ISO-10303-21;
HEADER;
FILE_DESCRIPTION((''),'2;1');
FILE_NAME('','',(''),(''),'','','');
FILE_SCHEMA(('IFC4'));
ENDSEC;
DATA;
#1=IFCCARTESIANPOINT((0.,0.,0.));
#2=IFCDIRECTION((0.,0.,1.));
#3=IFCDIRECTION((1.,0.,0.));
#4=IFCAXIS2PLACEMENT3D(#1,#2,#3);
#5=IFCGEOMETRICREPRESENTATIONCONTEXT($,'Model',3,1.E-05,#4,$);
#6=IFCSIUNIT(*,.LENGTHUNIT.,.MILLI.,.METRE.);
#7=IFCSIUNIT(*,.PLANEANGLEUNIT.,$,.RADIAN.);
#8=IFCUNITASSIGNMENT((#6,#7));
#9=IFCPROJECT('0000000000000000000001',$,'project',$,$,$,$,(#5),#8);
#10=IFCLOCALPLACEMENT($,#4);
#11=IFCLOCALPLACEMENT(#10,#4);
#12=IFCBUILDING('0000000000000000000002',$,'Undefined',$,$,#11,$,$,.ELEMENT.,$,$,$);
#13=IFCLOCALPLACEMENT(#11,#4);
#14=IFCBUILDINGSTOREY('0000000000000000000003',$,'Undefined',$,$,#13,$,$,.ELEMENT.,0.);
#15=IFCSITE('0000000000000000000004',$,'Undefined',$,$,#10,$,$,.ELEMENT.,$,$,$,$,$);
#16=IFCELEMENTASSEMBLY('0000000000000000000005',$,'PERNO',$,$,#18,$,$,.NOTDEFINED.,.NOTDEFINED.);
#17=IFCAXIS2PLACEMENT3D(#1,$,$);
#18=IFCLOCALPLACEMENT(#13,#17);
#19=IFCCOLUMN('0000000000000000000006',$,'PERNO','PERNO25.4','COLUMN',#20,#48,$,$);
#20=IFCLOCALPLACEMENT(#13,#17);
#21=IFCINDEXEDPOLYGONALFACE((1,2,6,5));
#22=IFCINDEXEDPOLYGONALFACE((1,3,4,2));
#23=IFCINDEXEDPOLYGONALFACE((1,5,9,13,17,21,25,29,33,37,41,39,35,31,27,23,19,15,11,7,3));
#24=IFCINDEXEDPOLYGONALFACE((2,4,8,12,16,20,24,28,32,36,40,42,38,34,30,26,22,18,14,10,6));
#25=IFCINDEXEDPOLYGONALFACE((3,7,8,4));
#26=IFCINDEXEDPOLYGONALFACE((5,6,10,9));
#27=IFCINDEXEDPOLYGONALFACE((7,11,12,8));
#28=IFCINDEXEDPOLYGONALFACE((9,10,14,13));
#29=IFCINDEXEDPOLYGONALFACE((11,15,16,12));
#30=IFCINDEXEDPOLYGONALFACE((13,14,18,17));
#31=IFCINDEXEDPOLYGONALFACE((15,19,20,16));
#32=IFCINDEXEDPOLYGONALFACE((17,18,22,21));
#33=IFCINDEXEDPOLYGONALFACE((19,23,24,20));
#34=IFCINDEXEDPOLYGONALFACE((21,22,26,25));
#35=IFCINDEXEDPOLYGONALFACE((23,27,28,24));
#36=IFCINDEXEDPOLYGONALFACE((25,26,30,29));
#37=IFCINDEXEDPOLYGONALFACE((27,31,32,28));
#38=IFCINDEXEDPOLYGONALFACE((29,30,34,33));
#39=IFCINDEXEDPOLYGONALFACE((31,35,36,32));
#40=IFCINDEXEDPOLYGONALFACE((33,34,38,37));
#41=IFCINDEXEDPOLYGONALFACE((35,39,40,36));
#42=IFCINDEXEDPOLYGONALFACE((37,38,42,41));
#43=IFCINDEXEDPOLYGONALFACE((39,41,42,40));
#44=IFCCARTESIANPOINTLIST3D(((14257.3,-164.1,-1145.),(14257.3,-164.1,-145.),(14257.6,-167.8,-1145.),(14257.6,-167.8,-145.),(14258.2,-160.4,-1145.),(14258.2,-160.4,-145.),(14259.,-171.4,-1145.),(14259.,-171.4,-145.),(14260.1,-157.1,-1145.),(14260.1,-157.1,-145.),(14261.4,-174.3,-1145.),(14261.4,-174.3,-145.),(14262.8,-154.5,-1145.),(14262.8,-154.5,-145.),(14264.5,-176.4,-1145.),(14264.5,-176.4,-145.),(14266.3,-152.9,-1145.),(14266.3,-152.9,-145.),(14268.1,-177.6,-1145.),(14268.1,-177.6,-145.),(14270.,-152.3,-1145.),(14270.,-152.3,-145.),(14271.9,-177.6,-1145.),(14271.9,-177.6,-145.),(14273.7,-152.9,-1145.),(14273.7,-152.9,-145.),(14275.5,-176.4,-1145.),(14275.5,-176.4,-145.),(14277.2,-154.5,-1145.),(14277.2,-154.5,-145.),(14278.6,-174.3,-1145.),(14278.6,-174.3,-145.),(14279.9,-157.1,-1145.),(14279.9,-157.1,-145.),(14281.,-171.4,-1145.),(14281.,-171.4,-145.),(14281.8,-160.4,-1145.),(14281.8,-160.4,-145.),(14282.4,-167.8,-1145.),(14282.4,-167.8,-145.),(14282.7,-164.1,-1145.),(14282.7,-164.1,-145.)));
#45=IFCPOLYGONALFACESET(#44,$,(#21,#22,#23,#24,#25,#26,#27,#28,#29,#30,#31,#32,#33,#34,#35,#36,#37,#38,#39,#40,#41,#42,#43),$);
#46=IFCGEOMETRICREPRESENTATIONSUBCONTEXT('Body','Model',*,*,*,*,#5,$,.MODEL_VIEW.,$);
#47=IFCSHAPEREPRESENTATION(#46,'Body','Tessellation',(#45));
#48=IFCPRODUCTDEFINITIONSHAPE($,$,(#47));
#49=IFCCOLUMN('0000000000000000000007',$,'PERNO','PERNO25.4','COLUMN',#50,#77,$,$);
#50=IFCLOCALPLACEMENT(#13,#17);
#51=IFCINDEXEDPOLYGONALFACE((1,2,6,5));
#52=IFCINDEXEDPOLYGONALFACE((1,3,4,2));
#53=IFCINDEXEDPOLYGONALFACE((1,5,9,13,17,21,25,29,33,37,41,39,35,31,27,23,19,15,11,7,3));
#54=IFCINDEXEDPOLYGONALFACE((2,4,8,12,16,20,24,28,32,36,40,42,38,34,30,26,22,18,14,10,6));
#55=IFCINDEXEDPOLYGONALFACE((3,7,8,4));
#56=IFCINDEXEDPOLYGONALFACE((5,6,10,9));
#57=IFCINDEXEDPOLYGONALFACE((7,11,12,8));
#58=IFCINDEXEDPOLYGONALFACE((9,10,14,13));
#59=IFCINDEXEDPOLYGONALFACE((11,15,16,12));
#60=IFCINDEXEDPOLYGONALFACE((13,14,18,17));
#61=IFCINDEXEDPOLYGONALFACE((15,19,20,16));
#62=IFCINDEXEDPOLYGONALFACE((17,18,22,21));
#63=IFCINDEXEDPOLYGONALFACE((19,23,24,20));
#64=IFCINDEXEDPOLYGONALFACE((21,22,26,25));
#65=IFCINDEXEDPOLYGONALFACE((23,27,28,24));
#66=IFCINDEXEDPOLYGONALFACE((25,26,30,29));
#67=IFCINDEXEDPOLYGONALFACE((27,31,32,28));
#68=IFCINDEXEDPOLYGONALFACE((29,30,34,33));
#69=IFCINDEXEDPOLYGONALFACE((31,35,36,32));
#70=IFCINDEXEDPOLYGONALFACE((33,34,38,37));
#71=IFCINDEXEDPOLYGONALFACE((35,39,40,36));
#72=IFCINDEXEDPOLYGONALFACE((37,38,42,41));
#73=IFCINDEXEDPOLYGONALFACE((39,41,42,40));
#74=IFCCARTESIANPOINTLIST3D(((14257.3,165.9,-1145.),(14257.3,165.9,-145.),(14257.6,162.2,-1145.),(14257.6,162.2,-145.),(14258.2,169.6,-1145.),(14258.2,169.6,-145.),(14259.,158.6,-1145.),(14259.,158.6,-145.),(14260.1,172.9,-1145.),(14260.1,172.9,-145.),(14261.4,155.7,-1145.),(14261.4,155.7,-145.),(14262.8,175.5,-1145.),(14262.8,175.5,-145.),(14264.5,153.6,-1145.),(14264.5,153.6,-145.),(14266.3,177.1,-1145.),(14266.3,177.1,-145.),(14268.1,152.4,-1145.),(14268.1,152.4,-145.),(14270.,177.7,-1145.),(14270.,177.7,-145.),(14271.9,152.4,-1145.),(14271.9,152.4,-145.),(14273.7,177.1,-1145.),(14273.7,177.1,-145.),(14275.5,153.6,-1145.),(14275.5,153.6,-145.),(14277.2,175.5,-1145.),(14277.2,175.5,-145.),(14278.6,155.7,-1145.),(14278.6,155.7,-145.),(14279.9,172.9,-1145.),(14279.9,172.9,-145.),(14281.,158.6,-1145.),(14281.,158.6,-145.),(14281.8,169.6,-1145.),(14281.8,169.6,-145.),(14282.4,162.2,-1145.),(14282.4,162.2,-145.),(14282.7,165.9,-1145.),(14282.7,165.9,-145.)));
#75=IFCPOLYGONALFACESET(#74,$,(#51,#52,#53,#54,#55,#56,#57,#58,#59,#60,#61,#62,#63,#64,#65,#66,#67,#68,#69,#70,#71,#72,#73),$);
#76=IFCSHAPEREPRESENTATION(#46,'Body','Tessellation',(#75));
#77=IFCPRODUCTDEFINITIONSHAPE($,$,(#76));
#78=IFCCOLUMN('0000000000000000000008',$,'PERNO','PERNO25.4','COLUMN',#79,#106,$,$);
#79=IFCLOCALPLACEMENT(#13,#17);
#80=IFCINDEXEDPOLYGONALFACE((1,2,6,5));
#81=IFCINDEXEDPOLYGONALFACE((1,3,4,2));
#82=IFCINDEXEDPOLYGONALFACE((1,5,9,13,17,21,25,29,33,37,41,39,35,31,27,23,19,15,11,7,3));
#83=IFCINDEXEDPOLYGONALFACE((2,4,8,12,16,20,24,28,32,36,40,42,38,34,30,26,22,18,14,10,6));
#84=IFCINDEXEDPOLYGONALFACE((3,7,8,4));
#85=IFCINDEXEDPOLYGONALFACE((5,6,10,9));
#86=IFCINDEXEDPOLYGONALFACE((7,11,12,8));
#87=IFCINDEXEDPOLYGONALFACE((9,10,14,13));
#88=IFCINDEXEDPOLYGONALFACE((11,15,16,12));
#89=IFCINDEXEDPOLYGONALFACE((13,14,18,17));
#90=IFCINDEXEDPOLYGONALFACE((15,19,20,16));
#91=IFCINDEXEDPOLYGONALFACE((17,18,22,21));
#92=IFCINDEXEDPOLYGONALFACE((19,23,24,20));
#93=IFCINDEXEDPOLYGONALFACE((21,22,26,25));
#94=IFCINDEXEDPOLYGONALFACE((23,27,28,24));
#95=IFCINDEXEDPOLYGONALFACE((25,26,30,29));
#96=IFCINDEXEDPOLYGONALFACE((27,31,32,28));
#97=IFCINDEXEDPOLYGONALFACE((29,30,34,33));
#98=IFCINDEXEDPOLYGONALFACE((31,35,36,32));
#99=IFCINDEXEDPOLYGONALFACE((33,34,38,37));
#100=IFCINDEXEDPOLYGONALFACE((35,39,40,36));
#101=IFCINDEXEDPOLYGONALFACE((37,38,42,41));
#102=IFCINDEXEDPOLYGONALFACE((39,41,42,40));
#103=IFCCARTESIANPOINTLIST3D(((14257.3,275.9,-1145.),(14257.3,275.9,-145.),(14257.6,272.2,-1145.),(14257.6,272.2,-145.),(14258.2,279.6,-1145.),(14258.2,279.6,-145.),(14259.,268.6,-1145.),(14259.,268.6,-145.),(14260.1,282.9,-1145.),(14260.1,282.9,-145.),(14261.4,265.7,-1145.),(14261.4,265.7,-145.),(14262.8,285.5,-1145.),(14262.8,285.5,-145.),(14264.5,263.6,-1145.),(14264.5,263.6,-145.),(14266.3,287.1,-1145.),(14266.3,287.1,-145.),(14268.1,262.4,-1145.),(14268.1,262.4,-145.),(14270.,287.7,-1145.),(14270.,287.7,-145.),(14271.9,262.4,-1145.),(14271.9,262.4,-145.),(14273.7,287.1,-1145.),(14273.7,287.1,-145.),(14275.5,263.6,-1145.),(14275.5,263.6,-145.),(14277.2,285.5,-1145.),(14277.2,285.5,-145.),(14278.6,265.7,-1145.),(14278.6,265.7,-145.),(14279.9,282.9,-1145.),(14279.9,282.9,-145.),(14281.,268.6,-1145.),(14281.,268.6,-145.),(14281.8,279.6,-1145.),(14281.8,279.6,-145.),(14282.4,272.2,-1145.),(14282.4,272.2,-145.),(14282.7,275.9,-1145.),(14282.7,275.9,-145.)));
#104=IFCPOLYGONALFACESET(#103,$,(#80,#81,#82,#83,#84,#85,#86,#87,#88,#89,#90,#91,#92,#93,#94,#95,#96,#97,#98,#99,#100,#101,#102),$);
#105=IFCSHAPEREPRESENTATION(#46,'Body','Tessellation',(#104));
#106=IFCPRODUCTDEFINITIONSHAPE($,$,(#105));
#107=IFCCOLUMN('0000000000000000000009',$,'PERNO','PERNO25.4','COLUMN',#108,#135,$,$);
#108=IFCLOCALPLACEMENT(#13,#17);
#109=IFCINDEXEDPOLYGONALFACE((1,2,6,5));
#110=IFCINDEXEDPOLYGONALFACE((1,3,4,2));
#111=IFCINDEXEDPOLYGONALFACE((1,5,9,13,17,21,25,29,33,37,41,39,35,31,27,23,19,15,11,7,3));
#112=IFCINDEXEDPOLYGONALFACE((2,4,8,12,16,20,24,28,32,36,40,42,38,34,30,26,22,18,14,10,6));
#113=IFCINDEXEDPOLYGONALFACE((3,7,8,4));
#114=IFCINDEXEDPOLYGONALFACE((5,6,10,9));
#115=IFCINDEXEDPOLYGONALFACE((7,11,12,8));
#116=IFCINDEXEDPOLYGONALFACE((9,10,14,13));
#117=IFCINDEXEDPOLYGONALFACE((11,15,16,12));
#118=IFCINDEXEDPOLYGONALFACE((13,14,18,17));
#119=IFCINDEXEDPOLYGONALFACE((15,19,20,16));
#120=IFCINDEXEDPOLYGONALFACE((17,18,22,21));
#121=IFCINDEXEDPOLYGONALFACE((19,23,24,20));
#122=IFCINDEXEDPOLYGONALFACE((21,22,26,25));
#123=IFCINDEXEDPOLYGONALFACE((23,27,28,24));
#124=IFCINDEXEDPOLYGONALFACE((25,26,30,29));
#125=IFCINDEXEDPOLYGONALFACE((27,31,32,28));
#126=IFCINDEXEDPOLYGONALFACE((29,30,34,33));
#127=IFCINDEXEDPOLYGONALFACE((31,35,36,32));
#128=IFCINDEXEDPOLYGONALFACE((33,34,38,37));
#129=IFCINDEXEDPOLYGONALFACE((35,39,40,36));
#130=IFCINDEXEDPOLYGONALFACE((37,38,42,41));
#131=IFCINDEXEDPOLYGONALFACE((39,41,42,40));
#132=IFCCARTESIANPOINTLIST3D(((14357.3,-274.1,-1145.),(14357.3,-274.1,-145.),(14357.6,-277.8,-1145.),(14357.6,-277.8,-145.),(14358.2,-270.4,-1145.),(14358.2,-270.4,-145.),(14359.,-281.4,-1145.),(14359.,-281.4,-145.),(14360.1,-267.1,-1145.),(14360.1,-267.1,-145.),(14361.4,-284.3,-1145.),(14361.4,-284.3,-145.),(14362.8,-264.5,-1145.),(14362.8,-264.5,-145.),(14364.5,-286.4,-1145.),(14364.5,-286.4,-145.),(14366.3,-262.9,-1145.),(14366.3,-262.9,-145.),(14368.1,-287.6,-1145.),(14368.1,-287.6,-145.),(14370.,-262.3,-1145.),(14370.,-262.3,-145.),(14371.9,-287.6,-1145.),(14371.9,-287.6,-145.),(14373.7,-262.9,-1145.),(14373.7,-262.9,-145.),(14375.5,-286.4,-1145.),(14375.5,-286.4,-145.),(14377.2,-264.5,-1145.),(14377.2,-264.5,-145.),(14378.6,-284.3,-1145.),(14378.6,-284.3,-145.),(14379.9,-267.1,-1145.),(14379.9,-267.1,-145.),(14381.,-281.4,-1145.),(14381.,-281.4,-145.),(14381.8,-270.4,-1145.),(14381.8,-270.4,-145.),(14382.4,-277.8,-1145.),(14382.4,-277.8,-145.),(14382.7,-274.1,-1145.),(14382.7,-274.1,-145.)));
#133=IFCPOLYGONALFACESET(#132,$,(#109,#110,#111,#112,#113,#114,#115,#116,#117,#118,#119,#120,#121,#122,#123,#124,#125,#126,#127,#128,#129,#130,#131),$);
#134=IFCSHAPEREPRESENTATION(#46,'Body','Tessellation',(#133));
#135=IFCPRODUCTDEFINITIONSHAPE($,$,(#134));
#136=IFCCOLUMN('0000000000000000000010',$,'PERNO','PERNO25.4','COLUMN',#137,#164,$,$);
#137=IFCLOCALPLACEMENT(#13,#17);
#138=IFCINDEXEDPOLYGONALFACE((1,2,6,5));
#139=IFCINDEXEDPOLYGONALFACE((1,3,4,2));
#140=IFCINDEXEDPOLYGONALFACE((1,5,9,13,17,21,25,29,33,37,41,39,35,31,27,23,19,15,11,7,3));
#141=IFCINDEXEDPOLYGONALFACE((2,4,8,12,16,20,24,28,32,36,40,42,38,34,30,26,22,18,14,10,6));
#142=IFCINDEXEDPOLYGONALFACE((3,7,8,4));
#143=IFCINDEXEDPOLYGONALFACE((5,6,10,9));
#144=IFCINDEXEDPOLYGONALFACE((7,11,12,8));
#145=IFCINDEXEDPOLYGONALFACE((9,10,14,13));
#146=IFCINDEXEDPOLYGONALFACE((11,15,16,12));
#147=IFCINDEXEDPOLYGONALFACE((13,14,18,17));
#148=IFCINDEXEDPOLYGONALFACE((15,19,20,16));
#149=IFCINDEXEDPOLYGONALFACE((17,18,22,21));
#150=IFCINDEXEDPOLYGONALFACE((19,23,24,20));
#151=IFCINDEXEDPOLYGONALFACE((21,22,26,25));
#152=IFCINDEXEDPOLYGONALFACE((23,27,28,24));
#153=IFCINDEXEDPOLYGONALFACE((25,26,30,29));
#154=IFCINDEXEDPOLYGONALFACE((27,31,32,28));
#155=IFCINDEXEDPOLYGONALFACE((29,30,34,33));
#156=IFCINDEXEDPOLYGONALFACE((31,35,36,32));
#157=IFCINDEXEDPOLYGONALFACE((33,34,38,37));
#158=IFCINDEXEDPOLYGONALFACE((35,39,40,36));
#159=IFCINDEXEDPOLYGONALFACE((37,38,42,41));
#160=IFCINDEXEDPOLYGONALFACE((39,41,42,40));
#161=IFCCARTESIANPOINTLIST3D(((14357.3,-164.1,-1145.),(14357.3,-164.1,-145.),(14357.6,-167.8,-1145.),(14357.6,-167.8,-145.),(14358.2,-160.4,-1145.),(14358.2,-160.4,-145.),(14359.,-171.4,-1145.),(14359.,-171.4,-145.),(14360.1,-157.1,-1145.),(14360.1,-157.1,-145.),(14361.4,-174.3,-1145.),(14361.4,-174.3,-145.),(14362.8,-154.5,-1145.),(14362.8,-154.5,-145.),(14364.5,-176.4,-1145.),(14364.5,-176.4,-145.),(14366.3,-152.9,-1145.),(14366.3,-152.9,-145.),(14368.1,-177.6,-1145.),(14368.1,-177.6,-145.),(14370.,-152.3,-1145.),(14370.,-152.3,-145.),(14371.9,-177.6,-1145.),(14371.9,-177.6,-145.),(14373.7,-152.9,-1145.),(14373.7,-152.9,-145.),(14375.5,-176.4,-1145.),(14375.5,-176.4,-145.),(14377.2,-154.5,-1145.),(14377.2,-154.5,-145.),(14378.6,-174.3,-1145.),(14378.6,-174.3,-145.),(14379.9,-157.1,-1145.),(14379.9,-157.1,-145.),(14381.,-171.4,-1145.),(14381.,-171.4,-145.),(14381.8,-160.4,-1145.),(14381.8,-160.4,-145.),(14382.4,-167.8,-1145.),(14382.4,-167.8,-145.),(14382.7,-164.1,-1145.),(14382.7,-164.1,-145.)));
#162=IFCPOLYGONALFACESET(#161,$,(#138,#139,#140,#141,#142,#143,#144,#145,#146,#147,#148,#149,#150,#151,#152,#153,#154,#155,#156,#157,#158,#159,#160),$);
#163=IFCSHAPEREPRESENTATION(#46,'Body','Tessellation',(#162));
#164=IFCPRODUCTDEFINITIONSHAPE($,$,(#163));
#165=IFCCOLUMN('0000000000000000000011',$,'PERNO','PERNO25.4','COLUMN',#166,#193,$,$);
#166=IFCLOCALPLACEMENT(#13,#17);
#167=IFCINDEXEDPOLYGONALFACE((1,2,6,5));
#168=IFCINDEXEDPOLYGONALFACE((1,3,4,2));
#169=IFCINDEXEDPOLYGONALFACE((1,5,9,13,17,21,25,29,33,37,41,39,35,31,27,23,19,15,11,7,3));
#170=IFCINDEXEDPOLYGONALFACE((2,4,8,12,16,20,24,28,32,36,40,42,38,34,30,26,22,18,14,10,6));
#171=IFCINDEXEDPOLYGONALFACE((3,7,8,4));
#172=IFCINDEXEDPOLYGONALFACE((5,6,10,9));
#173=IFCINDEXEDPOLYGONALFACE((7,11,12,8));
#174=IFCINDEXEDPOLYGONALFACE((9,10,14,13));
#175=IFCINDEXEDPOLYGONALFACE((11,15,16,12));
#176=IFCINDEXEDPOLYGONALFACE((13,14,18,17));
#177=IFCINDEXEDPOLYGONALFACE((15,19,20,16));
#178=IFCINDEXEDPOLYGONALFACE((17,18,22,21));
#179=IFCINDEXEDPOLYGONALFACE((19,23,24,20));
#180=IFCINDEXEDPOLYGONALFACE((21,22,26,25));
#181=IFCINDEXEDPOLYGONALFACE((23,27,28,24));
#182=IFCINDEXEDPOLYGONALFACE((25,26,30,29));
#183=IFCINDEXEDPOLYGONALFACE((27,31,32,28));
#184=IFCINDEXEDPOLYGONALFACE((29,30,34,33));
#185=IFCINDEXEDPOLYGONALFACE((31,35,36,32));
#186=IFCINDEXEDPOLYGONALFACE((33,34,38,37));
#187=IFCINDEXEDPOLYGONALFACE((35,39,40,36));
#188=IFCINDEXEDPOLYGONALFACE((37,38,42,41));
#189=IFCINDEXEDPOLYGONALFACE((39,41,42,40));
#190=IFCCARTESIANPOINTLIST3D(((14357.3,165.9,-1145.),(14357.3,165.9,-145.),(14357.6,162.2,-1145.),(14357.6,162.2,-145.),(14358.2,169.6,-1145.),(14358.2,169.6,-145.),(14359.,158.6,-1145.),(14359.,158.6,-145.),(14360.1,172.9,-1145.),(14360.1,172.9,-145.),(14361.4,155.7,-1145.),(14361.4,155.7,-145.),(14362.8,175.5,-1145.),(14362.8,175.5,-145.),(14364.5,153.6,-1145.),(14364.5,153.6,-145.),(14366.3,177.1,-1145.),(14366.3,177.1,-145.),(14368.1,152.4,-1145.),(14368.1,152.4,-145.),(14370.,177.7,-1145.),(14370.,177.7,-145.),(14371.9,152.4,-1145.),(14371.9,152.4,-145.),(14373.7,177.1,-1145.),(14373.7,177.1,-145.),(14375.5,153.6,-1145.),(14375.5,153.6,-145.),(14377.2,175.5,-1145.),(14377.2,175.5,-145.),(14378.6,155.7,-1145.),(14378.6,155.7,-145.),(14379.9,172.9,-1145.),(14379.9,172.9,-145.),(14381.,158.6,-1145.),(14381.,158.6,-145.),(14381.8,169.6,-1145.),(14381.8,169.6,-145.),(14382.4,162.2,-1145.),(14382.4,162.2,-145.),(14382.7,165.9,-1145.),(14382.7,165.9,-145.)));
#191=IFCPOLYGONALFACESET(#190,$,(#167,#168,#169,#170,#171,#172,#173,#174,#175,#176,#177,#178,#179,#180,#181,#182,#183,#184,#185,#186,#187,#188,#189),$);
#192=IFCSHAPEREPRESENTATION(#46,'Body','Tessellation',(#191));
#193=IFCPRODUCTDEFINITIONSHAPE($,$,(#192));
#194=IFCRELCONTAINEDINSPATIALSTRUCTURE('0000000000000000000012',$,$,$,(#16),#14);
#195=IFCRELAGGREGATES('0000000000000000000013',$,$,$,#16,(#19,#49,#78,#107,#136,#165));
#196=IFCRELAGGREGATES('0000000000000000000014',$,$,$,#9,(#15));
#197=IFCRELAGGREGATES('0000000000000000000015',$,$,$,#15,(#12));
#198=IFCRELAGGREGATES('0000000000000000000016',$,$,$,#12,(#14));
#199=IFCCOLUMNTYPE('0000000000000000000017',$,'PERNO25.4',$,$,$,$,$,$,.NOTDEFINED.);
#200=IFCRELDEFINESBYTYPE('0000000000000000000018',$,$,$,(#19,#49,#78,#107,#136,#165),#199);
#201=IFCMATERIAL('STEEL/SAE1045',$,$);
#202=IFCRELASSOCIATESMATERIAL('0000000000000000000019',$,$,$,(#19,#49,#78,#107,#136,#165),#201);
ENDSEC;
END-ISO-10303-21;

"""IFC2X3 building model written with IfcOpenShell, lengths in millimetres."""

from ifc_helpers import new_model, si_unit, frame, origin_with_axes, origin_2d_with_axis, place, context, subcontext, project, spatial, circle, extrude, material, type_object, element, aggregate, save


model = new_model("IFC2X3")

# Units and contexts
model_context = context("Model", 3, precision=1e-05, world=origin_with_axes())
body_context = subcontext(model_context, "Body", "Model", "MODEL_VIEW")
ifc_project = project(units=[si_unit("LENGTHUNIT", "METRE", prefix="MILLI"), si_unit("PLANEANGLEUNIT", "RADIAN")], contexts=[model_context])

# Site, building, storey
site_placement = place(None, origin_with_axes())
site = spatial("IfcSite", under=ifc_project, at=site_placement, Name="Undefined", CompositionType="ELEMENT")
building_placement = place(site_placement, origin_with_axes())
building = spatial("IfcBuilding", under=site, at=building_placement, Name="Undefined", CompositionType="ELEMENT")
storey_placement = place(building_placement, origin_with_axes())
storey = spatial("IfcBuildingStorey", under=building, at=storey_placement, Name="Undefined", CompositionType="ELEMENT", Elevation=0.0)

# Element assembly, columns
assembly_1_placement = place(storey_placement, origin_with_axes())
assembly_1 = element("IfcElementAssembly", 1, at=assembly_1_placement, inside=storey, Name="PERNO", AssemblyPlace="NOTDEFINED", PredefinedType="NOTDEFINED")
ifc_material_1 = material(Name="STEEL/SAE1045")
column_type = type_object("IfcColumnType", Name="PERNO25.4", PredefinedType="NOTDEFINED")
column_1_placement = place(assembly_1_placement, frame((14270.0, -165.0, -1145.0), z_axis=(0.0, 0.0, 1.0), x_axis=(1.0, 0.0, 0.0)))
column_1 = element("IfcColumn", 2, at=column_1_placement, type_object=column_type, material=ifc_material_1, Name="PERNO", Description="PERNO25.4", ObjectType="COLUMN", context=body_context, shape_type="SweptSolid", body=[
    extrude(circle(Radius=12.7, at=origin_2d_with_axis()), frame((0.0, 0.0, 1000.0), z_axis=(0.0, 0.0, -1.0), x_axis=(0.0, 1.0, 0.0)), (0.0, 0.0, 1.0), 1000.0),
])
column_2_placement = place(assembly_1_placement, frame((14270.0, 165.0, -1145.0), z_axis=(0.0, 0.0, 1.0), x_axis=(1.0, 0.0, 0.0)))
column_2 = element("IfcColumn", 3, at=column_2_placement, type_object=column_type, material=ifc_material_1, Name="PERNO", Description="PERNO25.4", ObjectType="COLUMN", context=body_context, shape_type="SweptSolid", body=[
    extrude(circle(Radius=12.7, at=origin_2d_with_axis()), frame((0.0, 0.0, 1000.0), z_axis=(0.0, 0.0, -1.0), x_axis=(0.0, 1.0, 0.0)), (0.0, 0.0, 1.0), 1000.0),
])
column_3_placement = place(assembly_1_placement, frame((14270.0, 275.0, -1145.0), z_axis=(0.0, 0.0, 1.0), x_axis=(1.0, 0.0, 0.0)))
column_3 = element("IfcColumn", 4, at=column_3_placement, type_object=column_type, material=ifc_material_1, Name="PERNO", Description="PERNO25.4", ObjectType="COLUMN", context=body_context, shape_type="SweptSolid", body=[
    extrude(circle(Radius=12.7, at=origin_2d_with_axis()), frame((0.0, 0.0, 1000.0), z_axis=(0.0, 0.0, -1.0), x_axis=(0.0, 1.0, 0.0)), (0.0, 0.0, 1.0), 1000.0),
])
column_4_placement = place(assembly_1_placement, frame((14370.0, -275.0, -1145.0), z_axis=(0.0, 0.0, 1.0), x_axis=(1.0, 0.0, 0.0)))
column_4 = element("IfcColumn", 5, at=column_4_placement, type_object=column_type, material=ifc_material_1, Name="PERNO", Description="PERNO25.4", ObjectType="COLUMN", context=body_context, shape_type="SweptSolid", body=[
    extrude(circle(Radius=12.7, at=origin_2d_with_axis()), frame((0.0, 0.0, 1000.0), z_axis=(0.0, 0.0, -1.0), x_axis=(0.0, 1.0, 0.0)), (0.0, 0.0, 1.0), 1000.0),
])
column_5_placement = place(assembly_1_placement, frame((14370.0, -165.0, -1145.0), z_axis=(0.0, 0.0, 1.0), x_axis=(1.0, 0.0, 0.0)))
column_5 = element("IfcColumn", 6, at=column_5_placement, type_object=column_type, material=ifc_material_1, Name="PERNO", Description="PERNO25.4", ObjectType="COLUMN", context=body_context, shape_type="SweptSolid", body=[
    extrude(circle(Radius=12.7, at=origin_2d_with_axis()), frame((0.0, 0.0, 1000.0), z_axis=(0.0, 0.0, -1.0), x_axis=(0.0, 1.0, 0.0)), (0.0, 0.0, 1.0), 1000.0),
])
column_6_placement = place(assembly_1_placement, frame((14370.0, 165.0, -1145.0), z_axis=(0.0, 0.0, 1.0), x_axis=(1.0, 0.0, 0.0)))
column_6 = element("IfcColumn", 7, at=column_6_placement, type_object=column_type, material=ifc_material_1, Name="PERNO", Description="PERNO25.4", ObjectType="COLUMN", context=body_context, shape_type="SweptSolid", body=[
    extrude(circle(Radius=12.7, at=origin_2d_with_axis()), frame((0.0, 0.0, 1000.0), z_axis=(0.0, 0.0, -1.0), x_axis=(0.0, 1.0, 0.0)), (0.0, 0.0, 1.0), 1000.0),
])
aggregate(assembly_1, [column_1, column_2, column_3, column_4, column_5, column_6])

save(model, "model.ifc")
